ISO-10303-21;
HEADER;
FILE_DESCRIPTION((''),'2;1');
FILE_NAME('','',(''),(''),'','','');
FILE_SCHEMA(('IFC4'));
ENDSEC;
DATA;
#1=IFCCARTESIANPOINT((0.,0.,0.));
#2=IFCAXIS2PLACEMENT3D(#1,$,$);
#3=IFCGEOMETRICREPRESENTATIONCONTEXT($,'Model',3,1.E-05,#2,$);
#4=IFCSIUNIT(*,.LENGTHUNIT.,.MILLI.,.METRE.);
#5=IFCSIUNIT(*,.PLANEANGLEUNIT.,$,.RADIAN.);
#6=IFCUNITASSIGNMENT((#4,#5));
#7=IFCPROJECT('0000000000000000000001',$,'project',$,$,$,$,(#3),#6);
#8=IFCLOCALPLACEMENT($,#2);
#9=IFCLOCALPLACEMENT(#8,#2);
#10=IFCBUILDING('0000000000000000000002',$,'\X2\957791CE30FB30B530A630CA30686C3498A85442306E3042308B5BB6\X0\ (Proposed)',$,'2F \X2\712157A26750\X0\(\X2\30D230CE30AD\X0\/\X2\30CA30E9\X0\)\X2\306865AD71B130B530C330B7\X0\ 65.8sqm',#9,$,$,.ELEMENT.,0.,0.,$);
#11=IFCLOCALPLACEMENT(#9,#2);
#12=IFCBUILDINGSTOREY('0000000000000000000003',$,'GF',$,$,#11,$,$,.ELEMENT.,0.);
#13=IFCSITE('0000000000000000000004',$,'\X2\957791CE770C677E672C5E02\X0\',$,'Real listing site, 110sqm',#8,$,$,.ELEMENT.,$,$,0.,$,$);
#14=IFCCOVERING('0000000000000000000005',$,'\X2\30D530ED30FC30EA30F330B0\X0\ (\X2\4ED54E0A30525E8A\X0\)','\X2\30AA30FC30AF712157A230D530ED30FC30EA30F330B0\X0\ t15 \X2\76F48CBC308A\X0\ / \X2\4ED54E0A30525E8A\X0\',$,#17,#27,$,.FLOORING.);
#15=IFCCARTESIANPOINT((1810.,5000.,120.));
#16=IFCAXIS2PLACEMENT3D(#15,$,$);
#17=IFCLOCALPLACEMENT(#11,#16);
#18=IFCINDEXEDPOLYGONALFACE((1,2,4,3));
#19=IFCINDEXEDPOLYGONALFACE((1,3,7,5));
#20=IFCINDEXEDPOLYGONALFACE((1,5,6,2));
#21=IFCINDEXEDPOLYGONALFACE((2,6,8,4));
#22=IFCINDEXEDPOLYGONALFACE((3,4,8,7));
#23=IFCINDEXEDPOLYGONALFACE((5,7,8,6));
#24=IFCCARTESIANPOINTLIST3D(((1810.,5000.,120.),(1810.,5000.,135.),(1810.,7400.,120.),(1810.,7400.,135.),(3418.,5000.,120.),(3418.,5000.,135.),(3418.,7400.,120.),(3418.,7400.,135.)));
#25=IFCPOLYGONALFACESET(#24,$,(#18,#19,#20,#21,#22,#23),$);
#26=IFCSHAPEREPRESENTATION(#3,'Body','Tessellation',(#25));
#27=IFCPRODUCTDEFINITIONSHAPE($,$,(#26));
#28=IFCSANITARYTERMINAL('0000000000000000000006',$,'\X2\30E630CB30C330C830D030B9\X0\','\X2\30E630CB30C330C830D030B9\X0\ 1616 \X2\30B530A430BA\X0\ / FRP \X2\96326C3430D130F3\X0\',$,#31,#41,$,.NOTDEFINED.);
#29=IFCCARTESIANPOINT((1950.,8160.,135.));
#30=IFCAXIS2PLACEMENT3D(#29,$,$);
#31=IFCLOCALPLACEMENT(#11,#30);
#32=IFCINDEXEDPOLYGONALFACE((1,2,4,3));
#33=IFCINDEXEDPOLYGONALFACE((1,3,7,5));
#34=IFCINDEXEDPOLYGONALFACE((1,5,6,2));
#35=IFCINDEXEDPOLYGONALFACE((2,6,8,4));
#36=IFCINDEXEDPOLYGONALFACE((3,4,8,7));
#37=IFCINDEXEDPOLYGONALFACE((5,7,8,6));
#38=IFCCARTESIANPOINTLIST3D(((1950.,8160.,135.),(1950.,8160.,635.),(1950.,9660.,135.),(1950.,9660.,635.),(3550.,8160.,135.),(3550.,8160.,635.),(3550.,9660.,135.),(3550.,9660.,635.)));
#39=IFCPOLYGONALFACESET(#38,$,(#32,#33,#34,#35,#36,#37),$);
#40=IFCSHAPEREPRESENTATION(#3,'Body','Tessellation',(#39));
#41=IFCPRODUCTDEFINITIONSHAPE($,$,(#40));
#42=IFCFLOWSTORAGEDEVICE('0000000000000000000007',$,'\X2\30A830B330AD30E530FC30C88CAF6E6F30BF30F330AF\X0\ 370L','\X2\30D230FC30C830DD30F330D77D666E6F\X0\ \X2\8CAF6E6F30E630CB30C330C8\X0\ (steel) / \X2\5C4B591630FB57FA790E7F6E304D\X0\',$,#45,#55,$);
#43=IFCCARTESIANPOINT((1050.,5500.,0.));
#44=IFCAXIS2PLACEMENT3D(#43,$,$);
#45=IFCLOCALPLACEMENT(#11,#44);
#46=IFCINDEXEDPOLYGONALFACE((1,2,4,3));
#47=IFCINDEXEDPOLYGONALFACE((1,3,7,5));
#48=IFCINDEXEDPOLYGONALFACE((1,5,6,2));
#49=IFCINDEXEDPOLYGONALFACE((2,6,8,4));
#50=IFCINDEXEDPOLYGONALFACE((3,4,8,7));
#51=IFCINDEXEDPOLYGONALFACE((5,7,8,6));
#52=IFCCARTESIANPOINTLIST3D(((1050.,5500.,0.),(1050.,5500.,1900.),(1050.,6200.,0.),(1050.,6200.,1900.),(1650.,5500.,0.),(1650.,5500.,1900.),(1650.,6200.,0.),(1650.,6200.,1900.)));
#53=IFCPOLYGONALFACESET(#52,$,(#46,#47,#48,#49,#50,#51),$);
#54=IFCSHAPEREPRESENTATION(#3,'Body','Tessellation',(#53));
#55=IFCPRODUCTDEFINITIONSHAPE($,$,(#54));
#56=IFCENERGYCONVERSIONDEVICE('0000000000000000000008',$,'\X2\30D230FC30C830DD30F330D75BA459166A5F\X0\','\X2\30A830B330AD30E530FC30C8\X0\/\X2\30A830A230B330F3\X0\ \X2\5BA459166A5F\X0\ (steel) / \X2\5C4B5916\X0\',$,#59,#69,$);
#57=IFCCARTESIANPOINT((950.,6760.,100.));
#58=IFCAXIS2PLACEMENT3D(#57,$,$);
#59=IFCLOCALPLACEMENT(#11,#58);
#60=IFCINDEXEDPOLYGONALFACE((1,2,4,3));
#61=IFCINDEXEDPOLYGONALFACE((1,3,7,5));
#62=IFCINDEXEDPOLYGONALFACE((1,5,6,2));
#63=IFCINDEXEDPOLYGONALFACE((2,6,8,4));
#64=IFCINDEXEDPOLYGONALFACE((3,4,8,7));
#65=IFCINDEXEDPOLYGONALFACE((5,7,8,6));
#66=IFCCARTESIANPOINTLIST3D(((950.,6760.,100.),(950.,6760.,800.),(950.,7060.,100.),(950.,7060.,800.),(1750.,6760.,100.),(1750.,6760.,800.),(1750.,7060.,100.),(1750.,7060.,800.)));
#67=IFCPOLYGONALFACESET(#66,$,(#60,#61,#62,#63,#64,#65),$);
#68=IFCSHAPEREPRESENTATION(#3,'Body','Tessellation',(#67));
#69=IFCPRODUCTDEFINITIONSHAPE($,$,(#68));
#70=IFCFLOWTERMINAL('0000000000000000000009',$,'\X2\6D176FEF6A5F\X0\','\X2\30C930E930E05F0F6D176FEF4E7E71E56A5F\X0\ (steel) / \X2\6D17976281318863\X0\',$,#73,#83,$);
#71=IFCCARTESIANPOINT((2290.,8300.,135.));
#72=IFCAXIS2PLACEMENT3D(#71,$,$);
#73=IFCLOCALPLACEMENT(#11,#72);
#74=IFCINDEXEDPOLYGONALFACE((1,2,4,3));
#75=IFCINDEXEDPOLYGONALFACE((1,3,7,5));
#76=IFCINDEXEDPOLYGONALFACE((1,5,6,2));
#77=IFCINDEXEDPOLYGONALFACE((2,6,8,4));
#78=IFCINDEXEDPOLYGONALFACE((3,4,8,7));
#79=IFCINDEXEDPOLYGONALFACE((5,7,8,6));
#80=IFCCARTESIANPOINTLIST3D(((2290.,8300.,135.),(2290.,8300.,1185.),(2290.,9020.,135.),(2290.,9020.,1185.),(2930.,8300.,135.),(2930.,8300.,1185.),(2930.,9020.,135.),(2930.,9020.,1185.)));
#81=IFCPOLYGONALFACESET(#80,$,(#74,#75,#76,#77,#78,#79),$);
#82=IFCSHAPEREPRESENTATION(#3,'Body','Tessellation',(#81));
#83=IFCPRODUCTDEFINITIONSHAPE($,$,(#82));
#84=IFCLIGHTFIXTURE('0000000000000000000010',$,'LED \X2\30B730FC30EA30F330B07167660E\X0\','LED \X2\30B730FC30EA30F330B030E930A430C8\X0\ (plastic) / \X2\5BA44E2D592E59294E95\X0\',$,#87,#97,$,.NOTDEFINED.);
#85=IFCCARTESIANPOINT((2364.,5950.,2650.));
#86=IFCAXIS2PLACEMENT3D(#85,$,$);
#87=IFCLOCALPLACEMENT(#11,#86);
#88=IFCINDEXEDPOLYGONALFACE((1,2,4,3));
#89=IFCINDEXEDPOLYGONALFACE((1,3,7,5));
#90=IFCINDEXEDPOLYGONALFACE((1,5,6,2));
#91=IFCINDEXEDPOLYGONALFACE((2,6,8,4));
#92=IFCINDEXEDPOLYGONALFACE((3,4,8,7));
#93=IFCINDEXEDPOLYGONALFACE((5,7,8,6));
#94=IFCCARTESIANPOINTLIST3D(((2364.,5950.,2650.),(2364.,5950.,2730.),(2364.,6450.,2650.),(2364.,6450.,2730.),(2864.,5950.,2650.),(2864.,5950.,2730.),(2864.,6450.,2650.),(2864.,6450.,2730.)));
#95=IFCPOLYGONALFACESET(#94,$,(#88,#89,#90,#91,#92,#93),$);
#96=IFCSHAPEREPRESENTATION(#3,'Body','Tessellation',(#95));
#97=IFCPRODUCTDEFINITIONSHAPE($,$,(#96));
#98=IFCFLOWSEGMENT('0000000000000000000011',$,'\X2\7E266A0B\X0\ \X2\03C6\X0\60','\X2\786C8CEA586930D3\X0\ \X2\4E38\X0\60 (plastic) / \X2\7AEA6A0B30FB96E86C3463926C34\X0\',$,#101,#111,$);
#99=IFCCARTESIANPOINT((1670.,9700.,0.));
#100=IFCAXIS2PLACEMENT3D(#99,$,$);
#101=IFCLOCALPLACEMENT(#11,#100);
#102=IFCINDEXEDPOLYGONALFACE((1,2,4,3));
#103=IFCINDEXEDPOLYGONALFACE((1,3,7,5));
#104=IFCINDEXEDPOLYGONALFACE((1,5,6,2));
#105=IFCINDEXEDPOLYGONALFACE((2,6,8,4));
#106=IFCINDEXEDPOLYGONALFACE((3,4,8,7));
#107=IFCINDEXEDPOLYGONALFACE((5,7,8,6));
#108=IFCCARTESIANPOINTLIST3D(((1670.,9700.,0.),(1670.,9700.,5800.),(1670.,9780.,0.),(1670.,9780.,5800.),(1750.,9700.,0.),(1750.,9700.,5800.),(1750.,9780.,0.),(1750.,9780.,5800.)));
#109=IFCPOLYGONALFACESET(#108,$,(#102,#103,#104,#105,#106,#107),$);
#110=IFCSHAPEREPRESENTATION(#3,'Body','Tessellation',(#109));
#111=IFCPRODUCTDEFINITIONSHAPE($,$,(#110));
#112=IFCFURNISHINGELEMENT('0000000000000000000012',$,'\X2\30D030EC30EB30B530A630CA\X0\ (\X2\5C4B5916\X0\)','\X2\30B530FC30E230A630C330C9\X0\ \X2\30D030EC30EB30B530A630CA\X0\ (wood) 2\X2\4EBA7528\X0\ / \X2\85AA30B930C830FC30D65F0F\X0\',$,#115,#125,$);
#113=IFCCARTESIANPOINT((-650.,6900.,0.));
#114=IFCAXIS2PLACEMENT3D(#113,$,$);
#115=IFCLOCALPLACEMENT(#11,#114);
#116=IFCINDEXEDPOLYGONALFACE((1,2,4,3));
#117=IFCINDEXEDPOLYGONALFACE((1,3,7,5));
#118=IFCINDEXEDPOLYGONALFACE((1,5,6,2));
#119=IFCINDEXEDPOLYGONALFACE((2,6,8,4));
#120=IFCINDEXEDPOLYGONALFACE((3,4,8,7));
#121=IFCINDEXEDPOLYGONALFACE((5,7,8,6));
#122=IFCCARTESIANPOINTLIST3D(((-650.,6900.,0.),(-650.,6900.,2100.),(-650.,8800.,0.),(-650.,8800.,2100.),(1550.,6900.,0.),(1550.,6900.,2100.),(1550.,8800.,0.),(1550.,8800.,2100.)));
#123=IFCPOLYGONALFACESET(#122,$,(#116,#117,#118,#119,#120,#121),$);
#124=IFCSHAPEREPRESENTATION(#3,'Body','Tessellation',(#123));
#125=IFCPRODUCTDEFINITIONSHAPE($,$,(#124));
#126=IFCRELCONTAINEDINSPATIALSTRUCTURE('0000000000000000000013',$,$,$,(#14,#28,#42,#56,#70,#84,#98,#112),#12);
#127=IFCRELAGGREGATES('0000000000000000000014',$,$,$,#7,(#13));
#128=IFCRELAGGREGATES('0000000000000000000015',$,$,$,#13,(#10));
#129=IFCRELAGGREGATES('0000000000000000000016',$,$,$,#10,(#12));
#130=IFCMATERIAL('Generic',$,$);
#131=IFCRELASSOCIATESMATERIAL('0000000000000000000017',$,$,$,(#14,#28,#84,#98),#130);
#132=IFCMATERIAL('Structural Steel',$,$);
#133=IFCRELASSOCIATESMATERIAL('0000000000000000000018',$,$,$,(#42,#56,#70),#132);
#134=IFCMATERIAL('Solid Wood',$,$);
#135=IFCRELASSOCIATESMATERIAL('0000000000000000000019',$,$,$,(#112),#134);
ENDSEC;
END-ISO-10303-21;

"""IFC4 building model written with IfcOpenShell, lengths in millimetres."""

from ifc_helpers import new_model, si_unit, frame, frame_2d, origin, place, context, project, spatial, rectangle, extrude, material, element, save


model = new_model("IFC4")

# Units and contexts
model_context = context("Model", 3, precision=1e-05, world=origin())
ifc_project = project(units=[si_unit("LENGTHUNIT", "METRE", prefix="MILLI"), si_unit("PLANEANGLEUNIT", "RADIAN")], contexts=[model_context])

# Site, building, storey
site_placement = place(None, origin())
site = spatial("IfcSite", under=ifc_project, at=site_placement, Name="長野県松本市", ObjectType="Real listing site, 110sqm", CompositionType="ELEMENT", RefElevation=0.0)
building_placement = place(site_placement, origin())
building = spatial("IfcBuilding", under=site, at=building_placement, Name="長野・サウナと水風呂のある家 (Proposed)", ObjectType="2F 無垢材(ヒノキ/ナラ)と断熱サッシ 65.8sqm", CompositionType="ELEMENT", ElevationOfRefHeight=0.0, ElevationOfTerrain=0.0)
storey_placement = place(building_placement, origin())
storey = spatial("IfcBuildingStorey", under=building, at=storey_placement, Name="GF", CompositionType="ELEMENT", Elevation=0.0)

# Shared definitions
ifc_material_1 = material(Name="Solid Wood")

# Covering
ifc_material_2 = material(Name="Generic")
covering_1_placement = place(storey_placement, frame((1810.0, 5000.0, 120.0)))
element("IfcCovering", 1, at=covering_1_placement, inside=storey, material=ifc_material_2, Name="フローリング (仕上げ床)", Description="オーク無垢フローリング t15 直貼り / 仕上げ床", PredefinedType="FLOORING", context=model_context, shape_type="SweptSolid", body=[
    extrude(rectangle(XDim=1608.0, YDim=2400.0, at=frame_2d((804.0, 1200.0))), frame((1810.0, 5000.0, 120.0)), (0.0, 0.0, 1.0), 15.0),
])

# Sanitary terminal
sanitary_terminal_placement = place(storey_placement, frame((1950.0, 8160.0, 135.0)))
element("IfcSanitaryTerminal", 2, at=sanitary_terminal_placement, inside=storey, material=ifc_material_2, Name="ユニットバス", Description="ユニットバス 1616 サイズ / FRP 防水パン", PredefinedType="NOTDEFINED", context=model_context, shape_type="SweptSolid", body=[
    extrude(rectangle(XDim=1600.0, YDim=1500.0, at=frame_2d((800.0, 750.0))), frame((1950.0, 8160.0, 135.0)), (0.0, 0.0, 1.0), 500.0),
])

# Flow storage device
ifc_material_3 = material(Name="Structural Steel")
flow_storage_device_placement = place(storey_placement, frame((1050.0, 5500.0, 0.0)))
element("IfcFlowStorageDevice", 3, at=flow_storage_device_placement, inside=storey, material=ifc_material_3, Name="エコキュート貯湯タンク 370L", Description="ヒートポンプ給湯 貯湯ユニット (steel) / 屋外・基礎置き", context=model_context, shape_type="SweptSolid", body=[
    extrude(rectangle(XDim=600.0, YDim=700.0, at=frame_2d((300.0, 350.0))), frame((1050.0, 5500.0, 0.0)), (0.0, 0.0, 1.0), 1900.0),
])

# Energy conversion device
energy_conversion_device_placement = place(storey_placement, frame((950.0, 6760.0, 100.0)))
element("IfcEnergyConversionDevice", 4, at=energy_conversion_device_placement, inside=storey, material=ifc_material_3, Name="ヒートポンプ室外機", Description="エコキュート/エアコン 室外機 (steel) / 屋外", context=model_context, shape_type="SweptSolid", body=[
    extrude(rectangle(XDim=800.0, YDim=300.0, at=frame_2d((400.0, 150.0))), frame((950.0, 6760.0, 100.0)), (0.0, 0.0, 1.0), 700.0),
])

# Flow terminal
flow_terminal_placement = place(storey_placement, frame((2290.0, 8300.0, 135.0)))
element("IfcFlowTerminal", 5, at=flow_terminal_placement, inside=storey, material=ifc_material_3, Name="洗濯機", Description="ドラム式洗濯乾燥機 (steel) / 洗面脱衣", context=model_context, shape_type="SweptSolid", body=[
    extrude(rectangle(XDim=640.0, YDim=720.0, at=frame_2d((320.0, 360.0))), frame((2290.0, 8300.0, 135.0)), (0.0, 0.0, 1.0), 1050.0),
])

# Light fixture
light_fixture_placement = place(storey_placement, frame((2364.0, 5950.0, 2650.0)))
element("IfcLightFixture", 6, at=light_fixture_placement, inside=storey, material=ifc_material_2, Name="LED シーリング照明", Description="LED シーリングライト (plastic) / 室中央天井", PredefinedType="NOTDEFINED", context=model_context, shape_type="SweptSolid", body=[
    extrude(rectangle(XDim=500.0, YDim=500.0, at=frame_2d((250.0, 250.0))), frame((2364.0, 5950.0, 2650.0)), (0.0, 0.0, 1.0), 80.0),
])

# Flow segment
flow_segment_placement = place(storey_placement, frame((1670.0, 9700.0, 0.0)))
element("IfcFlowSegment", 7, at=flow_segment_placement, inside=storey, material=ifc_material_2, Name="縦樋 φ60", Description="硬質塩ビ 丸60 (plastic) / 竪樋・雨水排水", context=model_context, shape_type="SweptSolid", body=[
    extrude(rectangle(XDim=80.0, YDim=80.0, at=frame_2d((40.0, 40.0))), frame((1670.0, 9700.0, 0.0)), (0.0, 0.0, 1.0), 5800.0),
])

# Furnishing element
furnishing_placement = place(storey_placement, frame((-650.0, 6900.0, 0.0)))
element("IfcFurnishingElement", 8, at=furnishing_placement, inside=storey, material=ifc_material_1, Name="バレルサウナ (屋外)", Description="サーモウッド バレルサウナ (wood) 2人用 / 薪ストーブ式", context=model_context, shape_type="SweptSolid", body=[
    extrude(rectangle(XDim=2200.0, YDim=1900.0, at=frame_2d((1100.0, 950.0))), frame((-650.0, 6900.0, 0.0)), (0.0, 0.0, 1.0), 2100.0),
])

save(model, "model.ifc")
